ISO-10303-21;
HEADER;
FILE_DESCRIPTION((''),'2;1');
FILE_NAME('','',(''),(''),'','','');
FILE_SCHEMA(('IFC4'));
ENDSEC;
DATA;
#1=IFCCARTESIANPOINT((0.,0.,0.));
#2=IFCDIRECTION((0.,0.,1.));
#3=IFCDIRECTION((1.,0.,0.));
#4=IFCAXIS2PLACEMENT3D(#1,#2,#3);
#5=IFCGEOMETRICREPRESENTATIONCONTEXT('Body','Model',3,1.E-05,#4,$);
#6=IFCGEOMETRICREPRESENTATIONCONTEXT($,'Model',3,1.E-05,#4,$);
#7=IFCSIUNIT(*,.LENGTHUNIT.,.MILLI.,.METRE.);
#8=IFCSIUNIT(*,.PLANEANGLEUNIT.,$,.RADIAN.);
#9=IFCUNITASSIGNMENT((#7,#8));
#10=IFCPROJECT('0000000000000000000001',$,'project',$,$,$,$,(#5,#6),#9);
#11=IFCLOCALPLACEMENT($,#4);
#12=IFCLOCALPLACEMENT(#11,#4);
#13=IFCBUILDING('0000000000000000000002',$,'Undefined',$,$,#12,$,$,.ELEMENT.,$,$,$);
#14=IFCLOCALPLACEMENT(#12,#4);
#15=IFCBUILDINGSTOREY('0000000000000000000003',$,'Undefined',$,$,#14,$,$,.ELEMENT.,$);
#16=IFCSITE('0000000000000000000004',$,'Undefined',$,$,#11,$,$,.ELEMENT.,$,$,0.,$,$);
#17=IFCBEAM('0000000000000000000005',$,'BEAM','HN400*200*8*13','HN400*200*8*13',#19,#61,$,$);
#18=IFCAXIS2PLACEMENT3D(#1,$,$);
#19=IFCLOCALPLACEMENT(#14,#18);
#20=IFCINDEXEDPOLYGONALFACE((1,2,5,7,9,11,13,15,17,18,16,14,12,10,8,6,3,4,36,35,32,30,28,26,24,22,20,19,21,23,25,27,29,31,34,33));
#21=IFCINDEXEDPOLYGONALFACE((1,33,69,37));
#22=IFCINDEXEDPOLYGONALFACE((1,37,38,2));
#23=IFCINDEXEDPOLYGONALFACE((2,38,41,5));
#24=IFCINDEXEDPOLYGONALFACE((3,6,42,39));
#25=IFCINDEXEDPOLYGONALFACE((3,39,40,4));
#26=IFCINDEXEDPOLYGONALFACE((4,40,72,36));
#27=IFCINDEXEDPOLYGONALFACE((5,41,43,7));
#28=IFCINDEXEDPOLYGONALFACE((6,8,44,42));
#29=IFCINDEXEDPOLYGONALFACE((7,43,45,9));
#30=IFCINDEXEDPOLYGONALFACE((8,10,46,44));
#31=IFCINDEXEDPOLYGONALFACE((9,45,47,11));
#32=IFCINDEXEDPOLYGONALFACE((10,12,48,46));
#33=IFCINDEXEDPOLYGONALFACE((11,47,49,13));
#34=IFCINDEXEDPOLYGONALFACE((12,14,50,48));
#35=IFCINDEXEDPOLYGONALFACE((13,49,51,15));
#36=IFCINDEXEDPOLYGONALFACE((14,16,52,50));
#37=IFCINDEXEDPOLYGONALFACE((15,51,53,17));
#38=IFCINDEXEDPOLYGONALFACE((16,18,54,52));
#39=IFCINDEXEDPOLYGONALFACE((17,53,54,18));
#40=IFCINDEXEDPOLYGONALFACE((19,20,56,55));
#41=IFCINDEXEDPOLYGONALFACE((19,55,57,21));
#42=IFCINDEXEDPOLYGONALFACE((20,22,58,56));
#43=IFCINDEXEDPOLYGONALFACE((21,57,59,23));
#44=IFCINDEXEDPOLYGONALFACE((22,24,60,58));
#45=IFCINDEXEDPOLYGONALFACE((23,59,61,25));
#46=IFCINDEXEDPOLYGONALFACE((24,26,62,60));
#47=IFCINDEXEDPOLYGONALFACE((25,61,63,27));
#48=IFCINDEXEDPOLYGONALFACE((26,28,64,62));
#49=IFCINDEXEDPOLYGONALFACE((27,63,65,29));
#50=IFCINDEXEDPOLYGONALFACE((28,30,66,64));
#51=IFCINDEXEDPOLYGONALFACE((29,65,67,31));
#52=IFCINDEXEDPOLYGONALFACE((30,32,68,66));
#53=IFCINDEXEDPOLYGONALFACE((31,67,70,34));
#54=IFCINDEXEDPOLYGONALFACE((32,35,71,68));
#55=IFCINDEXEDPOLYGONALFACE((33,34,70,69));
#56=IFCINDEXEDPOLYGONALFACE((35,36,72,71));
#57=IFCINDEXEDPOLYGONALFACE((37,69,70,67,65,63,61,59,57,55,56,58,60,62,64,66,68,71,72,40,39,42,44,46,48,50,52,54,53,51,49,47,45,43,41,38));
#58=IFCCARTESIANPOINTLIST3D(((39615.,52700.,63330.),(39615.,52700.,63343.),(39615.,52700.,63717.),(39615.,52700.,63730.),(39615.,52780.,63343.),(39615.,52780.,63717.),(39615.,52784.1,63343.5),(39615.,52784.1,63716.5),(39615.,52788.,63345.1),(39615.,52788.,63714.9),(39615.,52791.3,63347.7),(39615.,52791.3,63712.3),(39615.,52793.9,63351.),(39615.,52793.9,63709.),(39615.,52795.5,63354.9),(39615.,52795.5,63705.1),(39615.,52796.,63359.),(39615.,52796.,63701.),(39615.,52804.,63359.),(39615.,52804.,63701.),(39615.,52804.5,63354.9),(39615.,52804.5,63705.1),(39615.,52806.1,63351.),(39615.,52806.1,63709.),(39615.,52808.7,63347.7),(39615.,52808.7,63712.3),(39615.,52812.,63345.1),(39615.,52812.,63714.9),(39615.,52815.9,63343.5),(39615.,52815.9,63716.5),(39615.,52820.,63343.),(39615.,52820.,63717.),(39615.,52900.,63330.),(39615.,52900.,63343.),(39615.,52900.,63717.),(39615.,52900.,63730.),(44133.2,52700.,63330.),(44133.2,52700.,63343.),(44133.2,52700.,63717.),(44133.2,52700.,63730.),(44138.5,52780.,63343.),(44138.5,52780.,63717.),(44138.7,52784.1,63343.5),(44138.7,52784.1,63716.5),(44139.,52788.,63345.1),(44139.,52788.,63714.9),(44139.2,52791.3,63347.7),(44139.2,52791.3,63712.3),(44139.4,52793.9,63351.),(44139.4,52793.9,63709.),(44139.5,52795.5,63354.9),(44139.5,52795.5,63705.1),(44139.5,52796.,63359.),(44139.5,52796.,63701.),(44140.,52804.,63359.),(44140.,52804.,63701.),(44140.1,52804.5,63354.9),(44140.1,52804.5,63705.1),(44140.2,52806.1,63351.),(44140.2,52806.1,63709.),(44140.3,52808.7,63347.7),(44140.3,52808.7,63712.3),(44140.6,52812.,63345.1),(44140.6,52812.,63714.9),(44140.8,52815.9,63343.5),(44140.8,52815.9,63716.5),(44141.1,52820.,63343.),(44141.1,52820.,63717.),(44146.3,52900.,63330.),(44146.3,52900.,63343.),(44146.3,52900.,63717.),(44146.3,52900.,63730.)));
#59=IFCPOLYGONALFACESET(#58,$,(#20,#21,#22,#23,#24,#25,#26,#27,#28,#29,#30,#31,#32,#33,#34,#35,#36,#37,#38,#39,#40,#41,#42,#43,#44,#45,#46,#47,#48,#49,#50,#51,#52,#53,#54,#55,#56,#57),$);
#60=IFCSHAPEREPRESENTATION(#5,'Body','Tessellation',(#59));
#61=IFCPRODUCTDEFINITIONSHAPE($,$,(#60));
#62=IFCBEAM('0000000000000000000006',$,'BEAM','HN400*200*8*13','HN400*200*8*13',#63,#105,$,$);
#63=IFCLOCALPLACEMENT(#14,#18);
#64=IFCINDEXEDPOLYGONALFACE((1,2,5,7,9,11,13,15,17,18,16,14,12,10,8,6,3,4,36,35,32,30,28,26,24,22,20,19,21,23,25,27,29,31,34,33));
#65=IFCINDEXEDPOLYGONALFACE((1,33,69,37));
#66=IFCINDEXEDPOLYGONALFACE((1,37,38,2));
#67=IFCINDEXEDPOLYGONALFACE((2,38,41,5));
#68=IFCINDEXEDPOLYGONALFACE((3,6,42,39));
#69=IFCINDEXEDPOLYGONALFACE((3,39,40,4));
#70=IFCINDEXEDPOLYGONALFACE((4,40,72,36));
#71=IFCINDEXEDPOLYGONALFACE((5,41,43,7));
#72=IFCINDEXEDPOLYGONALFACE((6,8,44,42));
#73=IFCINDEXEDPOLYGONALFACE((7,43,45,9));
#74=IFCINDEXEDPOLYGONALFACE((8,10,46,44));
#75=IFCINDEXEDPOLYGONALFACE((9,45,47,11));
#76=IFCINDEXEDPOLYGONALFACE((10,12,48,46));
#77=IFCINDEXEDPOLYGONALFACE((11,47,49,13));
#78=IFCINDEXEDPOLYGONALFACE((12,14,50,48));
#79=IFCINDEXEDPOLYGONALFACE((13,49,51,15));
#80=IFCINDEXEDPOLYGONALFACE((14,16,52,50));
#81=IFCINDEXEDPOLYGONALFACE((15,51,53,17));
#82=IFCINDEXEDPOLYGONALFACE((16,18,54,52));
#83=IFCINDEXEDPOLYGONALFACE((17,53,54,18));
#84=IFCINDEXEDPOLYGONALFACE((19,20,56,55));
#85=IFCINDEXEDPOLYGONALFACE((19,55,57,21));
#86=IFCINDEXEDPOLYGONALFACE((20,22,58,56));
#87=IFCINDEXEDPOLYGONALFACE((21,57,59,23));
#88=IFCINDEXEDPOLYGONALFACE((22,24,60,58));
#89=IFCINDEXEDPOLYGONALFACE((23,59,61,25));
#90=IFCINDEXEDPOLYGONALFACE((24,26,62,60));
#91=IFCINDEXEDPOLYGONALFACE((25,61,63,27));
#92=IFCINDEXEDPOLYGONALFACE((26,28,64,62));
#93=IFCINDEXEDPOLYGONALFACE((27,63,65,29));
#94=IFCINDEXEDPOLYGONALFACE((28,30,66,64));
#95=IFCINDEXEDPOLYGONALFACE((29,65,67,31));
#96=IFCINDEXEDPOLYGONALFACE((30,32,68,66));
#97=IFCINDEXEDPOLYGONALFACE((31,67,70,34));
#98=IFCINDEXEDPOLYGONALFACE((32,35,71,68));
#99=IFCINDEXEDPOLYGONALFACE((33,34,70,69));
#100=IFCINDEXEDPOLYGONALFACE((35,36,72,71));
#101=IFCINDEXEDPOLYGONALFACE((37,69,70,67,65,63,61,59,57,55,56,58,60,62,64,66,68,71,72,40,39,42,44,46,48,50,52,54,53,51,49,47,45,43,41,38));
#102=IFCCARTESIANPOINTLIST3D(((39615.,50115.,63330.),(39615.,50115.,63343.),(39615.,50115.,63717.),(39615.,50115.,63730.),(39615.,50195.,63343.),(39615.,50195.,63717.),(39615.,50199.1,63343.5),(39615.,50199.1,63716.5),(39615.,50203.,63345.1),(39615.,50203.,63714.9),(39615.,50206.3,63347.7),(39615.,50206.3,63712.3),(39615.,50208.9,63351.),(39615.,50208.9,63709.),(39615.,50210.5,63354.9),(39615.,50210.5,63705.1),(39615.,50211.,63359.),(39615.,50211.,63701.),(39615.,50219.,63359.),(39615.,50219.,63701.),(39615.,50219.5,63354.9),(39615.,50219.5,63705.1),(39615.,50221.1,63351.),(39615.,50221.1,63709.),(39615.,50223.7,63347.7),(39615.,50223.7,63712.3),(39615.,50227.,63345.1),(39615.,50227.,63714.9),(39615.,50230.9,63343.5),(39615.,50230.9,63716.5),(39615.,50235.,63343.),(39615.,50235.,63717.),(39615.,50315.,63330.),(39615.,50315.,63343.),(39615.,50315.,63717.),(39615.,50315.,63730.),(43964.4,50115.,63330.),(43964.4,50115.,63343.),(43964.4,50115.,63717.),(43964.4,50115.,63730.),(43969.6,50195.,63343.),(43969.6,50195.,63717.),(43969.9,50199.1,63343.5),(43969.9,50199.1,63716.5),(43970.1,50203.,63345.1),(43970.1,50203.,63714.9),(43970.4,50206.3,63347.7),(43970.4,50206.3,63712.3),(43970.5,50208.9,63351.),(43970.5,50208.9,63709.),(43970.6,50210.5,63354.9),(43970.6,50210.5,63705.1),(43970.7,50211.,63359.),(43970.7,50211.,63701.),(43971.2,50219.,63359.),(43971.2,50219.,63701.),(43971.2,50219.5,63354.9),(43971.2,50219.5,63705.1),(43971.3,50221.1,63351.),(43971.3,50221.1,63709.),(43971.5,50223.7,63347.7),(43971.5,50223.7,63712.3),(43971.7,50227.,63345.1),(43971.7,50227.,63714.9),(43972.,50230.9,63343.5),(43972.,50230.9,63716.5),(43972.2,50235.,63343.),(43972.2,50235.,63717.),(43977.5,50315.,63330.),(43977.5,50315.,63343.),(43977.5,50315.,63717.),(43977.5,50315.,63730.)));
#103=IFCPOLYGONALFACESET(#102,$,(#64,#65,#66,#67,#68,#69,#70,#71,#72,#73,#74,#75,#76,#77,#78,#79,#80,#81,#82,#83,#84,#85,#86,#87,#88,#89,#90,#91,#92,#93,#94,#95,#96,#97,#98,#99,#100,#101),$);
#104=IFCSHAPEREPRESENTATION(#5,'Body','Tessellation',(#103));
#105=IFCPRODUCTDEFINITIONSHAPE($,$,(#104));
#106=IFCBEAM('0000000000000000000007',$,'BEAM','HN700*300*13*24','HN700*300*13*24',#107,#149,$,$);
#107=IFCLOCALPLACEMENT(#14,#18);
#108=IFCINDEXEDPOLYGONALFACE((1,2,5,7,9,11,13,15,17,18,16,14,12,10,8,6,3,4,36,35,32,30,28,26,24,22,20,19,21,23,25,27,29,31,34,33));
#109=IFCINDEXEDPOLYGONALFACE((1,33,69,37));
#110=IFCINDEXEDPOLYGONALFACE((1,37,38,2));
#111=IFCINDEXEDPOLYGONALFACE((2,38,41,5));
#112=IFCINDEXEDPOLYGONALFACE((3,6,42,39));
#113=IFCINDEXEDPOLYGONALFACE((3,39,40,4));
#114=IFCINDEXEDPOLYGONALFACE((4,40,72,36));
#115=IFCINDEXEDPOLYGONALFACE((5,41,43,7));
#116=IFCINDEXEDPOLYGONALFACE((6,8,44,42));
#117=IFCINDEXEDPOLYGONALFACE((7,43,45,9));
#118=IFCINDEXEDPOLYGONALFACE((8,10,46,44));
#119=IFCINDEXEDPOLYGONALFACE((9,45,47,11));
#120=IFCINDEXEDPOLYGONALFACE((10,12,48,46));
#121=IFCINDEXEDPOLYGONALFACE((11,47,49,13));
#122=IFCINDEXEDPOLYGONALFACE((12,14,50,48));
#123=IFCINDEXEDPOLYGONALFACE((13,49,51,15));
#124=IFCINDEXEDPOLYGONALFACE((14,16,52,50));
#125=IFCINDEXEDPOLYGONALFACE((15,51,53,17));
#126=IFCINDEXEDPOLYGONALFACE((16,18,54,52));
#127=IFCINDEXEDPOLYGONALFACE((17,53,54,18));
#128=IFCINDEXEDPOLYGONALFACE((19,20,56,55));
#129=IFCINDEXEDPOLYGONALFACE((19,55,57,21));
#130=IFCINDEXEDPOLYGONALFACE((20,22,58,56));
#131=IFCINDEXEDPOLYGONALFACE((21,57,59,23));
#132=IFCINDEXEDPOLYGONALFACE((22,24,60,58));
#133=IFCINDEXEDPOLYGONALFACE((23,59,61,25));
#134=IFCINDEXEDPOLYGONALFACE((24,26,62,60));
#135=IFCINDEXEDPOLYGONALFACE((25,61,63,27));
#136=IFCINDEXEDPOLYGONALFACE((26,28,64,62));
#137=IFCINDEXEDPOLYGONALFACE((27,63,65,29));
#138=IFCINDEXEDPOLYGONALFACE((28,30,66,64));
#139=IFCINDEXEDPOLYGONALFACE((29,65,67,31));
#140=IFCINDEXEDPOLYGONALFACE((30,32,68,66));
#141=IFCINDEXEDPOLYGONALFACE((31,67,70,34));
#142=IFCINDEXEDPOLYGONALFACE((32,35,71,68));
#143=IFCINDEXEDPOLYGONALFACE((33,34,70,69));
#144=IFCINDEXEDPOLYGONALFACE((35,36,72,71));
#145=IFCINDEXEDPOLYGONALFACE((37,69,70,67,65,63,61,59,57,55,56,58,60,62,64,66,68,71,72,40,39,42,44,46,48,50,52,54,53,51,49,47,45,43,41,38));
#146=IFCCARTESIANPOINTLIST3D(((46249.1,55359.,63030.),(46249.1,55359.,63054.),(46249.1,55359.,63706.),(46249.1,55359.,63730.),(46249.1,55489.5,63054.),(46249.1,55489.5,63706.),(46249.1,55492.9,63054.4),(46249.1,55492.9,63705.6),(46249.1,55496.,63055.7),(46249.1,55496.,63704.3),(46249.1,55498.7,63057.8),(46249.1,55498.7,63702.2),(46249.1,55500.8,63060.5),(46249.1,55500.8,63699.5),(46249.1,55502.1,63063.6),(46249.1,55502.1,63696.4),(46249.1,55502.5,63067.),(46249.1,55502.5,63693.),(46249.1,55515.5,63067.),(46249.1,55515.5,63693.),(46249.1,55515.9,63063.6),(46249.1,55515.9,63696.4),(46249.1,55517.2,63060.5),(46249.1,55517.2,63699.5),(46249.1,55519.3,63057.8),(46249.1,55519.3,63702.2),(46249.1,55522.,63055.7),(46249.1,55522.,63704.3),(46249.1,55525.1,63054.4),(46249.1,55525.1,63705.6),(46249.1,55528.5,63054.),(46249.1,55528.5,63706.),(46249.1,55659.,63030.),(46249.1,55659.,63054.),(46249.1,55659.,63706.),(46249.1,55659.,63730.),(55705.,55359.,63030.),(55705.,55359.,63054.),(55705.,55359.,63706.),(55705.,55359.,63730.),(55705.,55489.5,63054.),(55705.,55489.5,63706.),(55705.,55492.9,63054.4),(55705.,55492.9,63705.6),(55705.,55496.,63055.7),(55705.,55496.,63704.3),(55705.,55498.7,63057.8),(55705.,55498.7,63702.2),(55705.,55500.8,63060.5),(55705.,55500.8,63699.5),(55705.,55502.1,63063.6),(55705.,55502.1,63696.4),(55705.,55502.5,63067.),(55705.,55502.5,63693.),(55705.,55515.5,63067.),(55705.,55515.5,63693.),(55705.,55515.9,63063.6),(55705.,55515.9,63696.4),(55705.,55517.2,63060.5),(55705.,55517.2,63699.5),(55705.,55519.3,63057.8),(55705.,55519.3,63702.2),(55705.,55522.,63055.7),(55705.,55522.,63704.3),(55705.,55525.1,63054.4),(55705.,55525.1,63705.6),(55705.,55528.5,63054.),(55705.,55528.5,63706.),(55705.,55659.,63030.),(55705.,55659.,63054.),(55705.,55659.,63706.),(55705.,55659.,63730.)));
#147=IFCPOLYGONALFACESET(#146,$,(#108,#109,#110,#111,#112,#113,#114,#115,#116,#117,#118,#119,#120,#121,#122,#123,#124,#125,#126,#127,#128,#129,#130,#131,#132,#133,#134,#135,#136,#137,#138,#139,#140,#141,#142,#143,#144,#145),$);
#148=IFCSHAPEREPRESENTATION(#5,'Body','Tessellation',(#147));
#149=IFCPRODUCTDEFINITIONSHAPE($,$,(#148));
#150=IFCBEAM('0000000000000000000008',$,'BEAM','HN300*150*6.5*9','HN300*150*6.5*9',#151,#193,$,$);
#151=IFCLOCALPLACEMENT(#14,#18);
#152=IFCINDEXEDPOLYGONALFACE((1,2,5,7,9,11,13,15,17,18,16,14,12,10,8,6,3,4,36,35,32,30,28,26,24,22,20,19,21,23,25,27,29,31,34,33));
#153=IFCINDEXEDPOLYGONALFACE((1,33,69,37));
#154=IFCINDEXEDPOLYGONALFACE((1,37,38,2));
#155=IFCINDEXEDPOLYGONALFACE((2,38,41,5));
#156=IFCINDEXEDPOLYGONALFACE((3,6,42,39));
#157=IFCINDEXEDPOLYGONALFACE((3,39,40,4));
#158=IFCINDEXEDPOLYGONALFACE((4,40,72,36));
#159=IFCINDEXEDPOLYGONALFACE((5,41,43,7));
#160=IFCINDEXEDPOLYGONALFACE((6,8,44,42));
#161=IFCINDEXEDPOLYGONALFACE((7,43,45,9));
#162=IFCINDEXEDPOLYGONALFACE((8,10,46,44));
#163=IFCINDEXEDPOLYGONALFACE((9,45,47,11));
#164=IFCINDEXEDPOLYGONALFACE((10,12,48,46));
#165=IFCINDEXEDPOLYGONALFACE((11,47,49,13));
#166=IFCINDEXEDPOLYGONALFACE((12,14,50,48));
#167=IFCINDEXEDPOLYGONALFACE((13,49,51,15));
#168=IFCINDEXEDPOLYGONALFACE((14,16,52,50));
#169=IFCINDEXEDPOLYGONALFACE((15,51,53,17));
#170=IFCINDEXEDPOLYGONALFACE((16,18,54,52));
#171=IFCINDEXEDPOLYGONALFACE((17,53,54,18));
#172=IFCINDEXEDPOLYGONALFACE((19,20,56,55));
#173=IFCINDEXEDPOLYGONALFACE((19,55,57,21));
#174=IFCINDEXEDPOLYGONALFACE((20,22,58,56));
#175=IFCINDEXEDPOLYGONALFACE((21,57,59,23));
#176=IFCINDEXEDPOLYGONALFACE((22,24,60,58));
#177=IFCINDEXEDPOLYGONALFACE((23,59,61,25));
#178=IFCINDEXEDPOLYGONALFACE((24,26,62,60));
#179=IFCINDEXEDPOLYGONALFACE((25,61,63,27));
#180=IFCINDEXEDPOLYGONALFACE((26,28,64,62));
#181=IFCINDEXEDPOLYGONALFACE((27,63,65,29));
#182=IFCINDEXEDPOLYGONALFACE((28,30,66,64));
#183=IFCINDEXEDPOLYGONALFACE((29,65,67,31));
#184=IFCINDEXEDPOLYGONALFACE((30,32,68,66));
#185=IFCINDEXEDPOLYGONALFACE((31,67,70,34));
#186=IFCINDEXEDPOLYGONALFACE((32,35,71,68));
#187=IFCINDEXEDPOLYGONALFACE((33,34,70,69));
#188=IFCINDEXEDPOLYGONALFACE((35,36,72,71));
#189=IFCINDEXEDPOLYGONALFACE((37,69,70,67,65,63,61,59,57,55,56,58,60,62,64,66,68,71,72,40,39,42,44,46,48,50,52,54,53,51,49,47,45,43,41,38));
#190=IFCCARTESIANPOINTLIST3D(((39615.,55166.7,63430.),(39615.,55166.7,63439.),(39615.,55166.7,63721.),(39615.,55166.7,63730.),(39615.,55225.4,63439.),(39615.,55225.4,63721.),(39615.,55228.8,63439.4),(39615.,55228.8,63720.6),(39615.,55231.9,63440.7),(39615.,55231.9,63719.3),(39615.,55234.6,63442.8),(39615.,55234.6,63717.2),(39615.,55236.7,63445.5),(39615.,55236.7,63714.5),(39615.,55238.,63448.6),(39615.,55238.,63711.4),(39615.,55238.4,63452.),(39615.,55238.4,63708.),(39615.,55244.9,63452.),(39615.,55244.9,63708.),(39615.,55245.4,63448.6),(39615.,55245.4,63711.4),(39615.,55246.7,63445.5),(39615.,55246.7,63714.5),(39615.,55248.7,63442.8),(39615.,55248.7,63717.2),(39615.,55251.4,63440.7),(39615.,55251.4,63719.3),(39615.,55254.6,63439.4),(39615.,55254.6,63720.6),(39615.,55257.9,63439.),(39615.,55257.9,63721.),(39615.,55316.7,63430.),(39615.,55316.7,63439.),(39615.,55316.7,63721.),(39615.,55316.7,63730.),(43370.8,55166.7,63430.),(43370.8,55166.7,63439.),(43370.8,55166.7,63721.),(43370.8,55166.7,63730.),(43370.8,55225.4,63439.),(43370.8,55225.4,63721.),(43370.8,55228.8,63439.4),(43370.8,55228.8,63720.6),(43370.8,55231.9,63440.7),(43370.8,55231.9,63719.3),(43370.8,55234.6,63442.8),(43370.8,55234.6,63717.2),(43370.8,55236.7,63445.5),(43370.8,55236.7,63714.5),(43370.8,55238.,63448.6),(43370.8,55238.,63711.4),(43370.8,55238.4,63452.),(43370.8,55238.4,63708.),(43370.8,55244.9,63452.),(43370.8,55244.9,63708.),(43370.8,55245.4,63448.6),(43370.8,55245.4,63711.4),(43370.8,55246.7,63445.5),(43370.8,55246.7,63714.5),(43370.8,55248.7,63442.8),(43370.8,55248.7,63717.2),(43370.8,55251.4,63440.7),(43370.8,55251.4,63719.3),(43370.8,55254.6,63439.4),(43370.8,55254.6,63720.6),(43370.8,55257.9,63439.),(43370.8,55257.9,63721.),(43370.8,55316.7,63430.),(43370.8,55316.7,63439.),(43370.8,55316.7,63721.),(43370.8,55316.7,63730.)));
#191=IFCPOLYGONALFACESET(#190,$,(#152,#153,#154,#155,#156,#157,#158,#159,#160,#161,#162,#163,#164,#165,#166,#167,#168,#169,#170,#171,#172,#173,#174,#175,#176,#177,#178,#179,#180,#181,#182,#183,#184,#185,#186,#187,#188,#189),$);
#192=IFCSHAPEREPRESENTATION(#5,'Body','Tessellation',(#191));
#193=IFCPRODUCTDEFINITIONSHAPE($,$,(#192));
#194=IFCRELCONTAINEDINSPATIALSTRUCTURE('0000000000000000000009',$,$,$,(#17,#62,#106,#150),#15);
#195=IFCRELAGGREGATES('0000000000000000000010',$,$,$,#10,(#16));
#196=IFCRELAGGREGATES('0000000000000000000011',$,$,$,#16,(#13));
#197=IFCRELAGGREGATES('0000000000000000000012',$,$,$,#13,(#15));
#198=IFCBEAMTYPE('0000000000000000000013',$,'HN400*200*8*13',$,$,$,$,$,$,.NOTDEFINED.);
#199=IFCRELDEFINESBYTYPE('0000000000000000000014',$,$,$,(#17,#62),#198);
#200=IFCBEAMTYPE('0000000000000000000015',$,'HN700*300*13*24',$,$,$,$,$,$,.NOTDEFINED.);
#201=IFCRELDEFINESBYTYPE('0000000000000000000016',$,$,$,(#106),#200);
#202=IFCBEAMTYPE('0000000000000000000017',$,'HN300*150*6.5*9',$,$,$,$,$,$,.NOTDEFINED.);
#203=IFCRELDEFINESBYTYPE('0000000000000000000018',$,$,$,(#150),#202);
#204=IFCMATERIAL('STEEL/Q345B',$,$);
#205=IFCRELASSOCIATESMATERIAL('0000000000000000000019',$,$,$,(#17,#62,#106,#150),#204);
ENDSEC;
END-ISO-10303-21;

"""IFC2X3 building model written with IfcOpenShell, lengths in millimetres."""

from ifc_helpers import new_model, si_unit, frame, origin_with_axes, origin_2d_with_axis, place, context, project, spatial, i_section, extrude, clip, halfspace, material, type_object, element, save


model = new_model("IFC2X3")

# Units and contexts
model_context_1 = context("Model", 3, precision=1e-05, world=origin_with_axes(), identifier="Body")
model_context_2 = context("Model", 3, precision=1e-05, world=origin_with_axes())
ifc_project = project(units=[si_unit("LENGTHUNIT", "METRE", prefix="MILLI"), si_unit("PLANEANGLEUNIT", "RADIAN")], contexts=[model_context_1, model_context_2])

# Site, building, storey
site_placement = place(None, origin_with_axes())
site = spatial("IfcSite", under=ifc_project, at=site_placement, Name="Undefined", CompositionType="ELEMENT", RefElevation=0.0)
building_placement = place(site_placement, origin_with_axes())
building = spatial("IfcBuilding", under=site, at=building_placement, Name="Undefined", CompositionType="ELEMENT")
storey_placement = place(building_placement, origin_with_axes())
storey = spatial("IfcBuildingStorey", under=building, at=storey_placement, Name="Undefined", CompositionType="ELEMENT")

# Beams
ifc_material_1 = material(Name="STEEL/Q345B")
beam_type_1 = type_object("IfcBeamType", Name="HN400*200*8*13", PredefinedType="NOTDEFINED")
beam_1_placement = place(storey_placement, frame((44370.2, 52800.0, 63530.0), z_axis=(0.0, 0.0, 1.0), x_axis=(-1.0, 0.0, 0.0)))
element("IfcBeam", 1, at=beam_1_placement, inside=storey, type_object=beam_type_1, material=ifc_material_1, Name="BEAM", Description="HN400*200*8*13", ObjectType="HN400*200*8*13", context=model_context_1, shape_type="Clipping", body=[
    clip(clip(extrude(i_section(OverallWidth=200.0, OverallDepth=400.0, WebThickness=8.0, FlangeThickness=13.0, FilletRadius=16.0, at=origin_2d_with_axis()), frame((4755.2, 0.0, 0.0), z_axis=(-1.0, 0.0, 0.0), x_axis=(0.0, -1.0, 0.0)), (0.0, 0.0, 1.0), 4531.4), halfspace(frame((229.6, -13.2, 300.0), z_axis=(-0.997873, 0.065184, 0.0), x_axis=(-0.065183, -0.997873, 0.0)), False)), halfspace(frame((4755.2, 0.0, 300.0), z_axis=(1.0, 0.0, 0.0), x_axis=(0.0, 1.0, 0.0)), False)),
])
beam_2_placement = place(storey_placement, frame((44126.1, 50215.0, 63530.0), z_axis=(0.0, 0.0, 1.0), x_axis=(-1.0, 0.0, 0.0)))
element("IfcBeam", 2, at=beam_2_placement, inside=storey, type_object=beam_type_1, material=ifc_material_1, Name="BEAM", Description="HN400*200*8*13", ObjectType="HN400*200*8*13", context=model_context_1, shape_type="Clipping", body=[
    clip(clip(extrude(i_section(OverallWidth=200.0, OverallDepth=400.0, WebThickness=8.0, FlangeThickness=13.0, FilletRadius=16.0, at=origin_2d_with_axis()), frame((4511.1, 0.0, 0.0), z_axis=(-1.0, 0.0, 0.0), x_axis=(0.0, -1.0, 0.0)), (0.0, 0.0, 1.0), 4362.5), halfspace(frame((154.3, -13.2, 300.0), z_axis=(-0.997873, 0.065184, 0.0), x_axis=(-0.065183, -0.997873, 0.0)), False)), halfspace(frame((4511.1, 0.0, 300.0), z_axis=(1.0, 0.0, 0.0), x_axis=(0.0, 1.0, 0.0)), False)),
])
beam_type_2 = type_object("IfcBeamType", Name="HN700*300*13*24", PredefinedType="NOTDEFINED")
beam_3_placement = place(storey_placement, frame((46249.1, 55509.0, 63380.0), z_axis=(0.0, 0.0, 1.0), x_axis=(1.0, 0.0, 0.0)))
element("IfcBeam", 3, at=beam_3_placement, inside=storey, type_object=beam_type_2, material=ifc_material_1, Name="BEAM", Description="HN700*300*13*24", ObjectType="HN700*300*13*24", context=model_context_1, shape_type="SweptSolid", body=[
    extrude(i_section(OverallWidth=300.0, OverallDepth=700.0, WebThickness=13.0, FlangeThickness=24.0, FilletRadius=13.0, at=origin_2d_with_axis()), frame((9455.9, 0.0, 0.0), z_axis=(-1.0, 0.0, 0.0), x_axis=(0.0, -1.0, 0.0)), (0.0, 0.0, 1.0), 9455.9),
])
beam_type_3 = type_object("IfcBeamType", Name="HN300*150*6.5*9", PredefinedType="NOTDEFINED")
beam_4_placement = place(storey_placement, frame((43870.2, 55241.7, 63580.0), z_axis=(0.0, 0.0, 1.0), x_axis=(-1.0, 0.0, 0.0)))
element("IfcBeam", 4, at=beam_4_placement, inside=storey, type_object=beam_type_3, material=ifc_material_1, Name="BEAM", Description="HN300*150*6.5*9", ObjectType="HN300*150*6.5*9", context=model_context_1, shape_type="SweptSolid", body=[
    extrude(i_section(OverallWidth=150.0, OverallDepth=300.0, WebThickness=6.5, FlangeThickness=9.0, FilletRadius=13.0, at=origin_2d_with_axis()), frame((4255.2, 0.0, 0.0), z_axis=(-1.0, 0.0, 0.0), x_axis=(0.0, -1.0, 0.0)), (0.0, 0.0, 1.0), 3755.8),
])

save(model, "model.ifc")
